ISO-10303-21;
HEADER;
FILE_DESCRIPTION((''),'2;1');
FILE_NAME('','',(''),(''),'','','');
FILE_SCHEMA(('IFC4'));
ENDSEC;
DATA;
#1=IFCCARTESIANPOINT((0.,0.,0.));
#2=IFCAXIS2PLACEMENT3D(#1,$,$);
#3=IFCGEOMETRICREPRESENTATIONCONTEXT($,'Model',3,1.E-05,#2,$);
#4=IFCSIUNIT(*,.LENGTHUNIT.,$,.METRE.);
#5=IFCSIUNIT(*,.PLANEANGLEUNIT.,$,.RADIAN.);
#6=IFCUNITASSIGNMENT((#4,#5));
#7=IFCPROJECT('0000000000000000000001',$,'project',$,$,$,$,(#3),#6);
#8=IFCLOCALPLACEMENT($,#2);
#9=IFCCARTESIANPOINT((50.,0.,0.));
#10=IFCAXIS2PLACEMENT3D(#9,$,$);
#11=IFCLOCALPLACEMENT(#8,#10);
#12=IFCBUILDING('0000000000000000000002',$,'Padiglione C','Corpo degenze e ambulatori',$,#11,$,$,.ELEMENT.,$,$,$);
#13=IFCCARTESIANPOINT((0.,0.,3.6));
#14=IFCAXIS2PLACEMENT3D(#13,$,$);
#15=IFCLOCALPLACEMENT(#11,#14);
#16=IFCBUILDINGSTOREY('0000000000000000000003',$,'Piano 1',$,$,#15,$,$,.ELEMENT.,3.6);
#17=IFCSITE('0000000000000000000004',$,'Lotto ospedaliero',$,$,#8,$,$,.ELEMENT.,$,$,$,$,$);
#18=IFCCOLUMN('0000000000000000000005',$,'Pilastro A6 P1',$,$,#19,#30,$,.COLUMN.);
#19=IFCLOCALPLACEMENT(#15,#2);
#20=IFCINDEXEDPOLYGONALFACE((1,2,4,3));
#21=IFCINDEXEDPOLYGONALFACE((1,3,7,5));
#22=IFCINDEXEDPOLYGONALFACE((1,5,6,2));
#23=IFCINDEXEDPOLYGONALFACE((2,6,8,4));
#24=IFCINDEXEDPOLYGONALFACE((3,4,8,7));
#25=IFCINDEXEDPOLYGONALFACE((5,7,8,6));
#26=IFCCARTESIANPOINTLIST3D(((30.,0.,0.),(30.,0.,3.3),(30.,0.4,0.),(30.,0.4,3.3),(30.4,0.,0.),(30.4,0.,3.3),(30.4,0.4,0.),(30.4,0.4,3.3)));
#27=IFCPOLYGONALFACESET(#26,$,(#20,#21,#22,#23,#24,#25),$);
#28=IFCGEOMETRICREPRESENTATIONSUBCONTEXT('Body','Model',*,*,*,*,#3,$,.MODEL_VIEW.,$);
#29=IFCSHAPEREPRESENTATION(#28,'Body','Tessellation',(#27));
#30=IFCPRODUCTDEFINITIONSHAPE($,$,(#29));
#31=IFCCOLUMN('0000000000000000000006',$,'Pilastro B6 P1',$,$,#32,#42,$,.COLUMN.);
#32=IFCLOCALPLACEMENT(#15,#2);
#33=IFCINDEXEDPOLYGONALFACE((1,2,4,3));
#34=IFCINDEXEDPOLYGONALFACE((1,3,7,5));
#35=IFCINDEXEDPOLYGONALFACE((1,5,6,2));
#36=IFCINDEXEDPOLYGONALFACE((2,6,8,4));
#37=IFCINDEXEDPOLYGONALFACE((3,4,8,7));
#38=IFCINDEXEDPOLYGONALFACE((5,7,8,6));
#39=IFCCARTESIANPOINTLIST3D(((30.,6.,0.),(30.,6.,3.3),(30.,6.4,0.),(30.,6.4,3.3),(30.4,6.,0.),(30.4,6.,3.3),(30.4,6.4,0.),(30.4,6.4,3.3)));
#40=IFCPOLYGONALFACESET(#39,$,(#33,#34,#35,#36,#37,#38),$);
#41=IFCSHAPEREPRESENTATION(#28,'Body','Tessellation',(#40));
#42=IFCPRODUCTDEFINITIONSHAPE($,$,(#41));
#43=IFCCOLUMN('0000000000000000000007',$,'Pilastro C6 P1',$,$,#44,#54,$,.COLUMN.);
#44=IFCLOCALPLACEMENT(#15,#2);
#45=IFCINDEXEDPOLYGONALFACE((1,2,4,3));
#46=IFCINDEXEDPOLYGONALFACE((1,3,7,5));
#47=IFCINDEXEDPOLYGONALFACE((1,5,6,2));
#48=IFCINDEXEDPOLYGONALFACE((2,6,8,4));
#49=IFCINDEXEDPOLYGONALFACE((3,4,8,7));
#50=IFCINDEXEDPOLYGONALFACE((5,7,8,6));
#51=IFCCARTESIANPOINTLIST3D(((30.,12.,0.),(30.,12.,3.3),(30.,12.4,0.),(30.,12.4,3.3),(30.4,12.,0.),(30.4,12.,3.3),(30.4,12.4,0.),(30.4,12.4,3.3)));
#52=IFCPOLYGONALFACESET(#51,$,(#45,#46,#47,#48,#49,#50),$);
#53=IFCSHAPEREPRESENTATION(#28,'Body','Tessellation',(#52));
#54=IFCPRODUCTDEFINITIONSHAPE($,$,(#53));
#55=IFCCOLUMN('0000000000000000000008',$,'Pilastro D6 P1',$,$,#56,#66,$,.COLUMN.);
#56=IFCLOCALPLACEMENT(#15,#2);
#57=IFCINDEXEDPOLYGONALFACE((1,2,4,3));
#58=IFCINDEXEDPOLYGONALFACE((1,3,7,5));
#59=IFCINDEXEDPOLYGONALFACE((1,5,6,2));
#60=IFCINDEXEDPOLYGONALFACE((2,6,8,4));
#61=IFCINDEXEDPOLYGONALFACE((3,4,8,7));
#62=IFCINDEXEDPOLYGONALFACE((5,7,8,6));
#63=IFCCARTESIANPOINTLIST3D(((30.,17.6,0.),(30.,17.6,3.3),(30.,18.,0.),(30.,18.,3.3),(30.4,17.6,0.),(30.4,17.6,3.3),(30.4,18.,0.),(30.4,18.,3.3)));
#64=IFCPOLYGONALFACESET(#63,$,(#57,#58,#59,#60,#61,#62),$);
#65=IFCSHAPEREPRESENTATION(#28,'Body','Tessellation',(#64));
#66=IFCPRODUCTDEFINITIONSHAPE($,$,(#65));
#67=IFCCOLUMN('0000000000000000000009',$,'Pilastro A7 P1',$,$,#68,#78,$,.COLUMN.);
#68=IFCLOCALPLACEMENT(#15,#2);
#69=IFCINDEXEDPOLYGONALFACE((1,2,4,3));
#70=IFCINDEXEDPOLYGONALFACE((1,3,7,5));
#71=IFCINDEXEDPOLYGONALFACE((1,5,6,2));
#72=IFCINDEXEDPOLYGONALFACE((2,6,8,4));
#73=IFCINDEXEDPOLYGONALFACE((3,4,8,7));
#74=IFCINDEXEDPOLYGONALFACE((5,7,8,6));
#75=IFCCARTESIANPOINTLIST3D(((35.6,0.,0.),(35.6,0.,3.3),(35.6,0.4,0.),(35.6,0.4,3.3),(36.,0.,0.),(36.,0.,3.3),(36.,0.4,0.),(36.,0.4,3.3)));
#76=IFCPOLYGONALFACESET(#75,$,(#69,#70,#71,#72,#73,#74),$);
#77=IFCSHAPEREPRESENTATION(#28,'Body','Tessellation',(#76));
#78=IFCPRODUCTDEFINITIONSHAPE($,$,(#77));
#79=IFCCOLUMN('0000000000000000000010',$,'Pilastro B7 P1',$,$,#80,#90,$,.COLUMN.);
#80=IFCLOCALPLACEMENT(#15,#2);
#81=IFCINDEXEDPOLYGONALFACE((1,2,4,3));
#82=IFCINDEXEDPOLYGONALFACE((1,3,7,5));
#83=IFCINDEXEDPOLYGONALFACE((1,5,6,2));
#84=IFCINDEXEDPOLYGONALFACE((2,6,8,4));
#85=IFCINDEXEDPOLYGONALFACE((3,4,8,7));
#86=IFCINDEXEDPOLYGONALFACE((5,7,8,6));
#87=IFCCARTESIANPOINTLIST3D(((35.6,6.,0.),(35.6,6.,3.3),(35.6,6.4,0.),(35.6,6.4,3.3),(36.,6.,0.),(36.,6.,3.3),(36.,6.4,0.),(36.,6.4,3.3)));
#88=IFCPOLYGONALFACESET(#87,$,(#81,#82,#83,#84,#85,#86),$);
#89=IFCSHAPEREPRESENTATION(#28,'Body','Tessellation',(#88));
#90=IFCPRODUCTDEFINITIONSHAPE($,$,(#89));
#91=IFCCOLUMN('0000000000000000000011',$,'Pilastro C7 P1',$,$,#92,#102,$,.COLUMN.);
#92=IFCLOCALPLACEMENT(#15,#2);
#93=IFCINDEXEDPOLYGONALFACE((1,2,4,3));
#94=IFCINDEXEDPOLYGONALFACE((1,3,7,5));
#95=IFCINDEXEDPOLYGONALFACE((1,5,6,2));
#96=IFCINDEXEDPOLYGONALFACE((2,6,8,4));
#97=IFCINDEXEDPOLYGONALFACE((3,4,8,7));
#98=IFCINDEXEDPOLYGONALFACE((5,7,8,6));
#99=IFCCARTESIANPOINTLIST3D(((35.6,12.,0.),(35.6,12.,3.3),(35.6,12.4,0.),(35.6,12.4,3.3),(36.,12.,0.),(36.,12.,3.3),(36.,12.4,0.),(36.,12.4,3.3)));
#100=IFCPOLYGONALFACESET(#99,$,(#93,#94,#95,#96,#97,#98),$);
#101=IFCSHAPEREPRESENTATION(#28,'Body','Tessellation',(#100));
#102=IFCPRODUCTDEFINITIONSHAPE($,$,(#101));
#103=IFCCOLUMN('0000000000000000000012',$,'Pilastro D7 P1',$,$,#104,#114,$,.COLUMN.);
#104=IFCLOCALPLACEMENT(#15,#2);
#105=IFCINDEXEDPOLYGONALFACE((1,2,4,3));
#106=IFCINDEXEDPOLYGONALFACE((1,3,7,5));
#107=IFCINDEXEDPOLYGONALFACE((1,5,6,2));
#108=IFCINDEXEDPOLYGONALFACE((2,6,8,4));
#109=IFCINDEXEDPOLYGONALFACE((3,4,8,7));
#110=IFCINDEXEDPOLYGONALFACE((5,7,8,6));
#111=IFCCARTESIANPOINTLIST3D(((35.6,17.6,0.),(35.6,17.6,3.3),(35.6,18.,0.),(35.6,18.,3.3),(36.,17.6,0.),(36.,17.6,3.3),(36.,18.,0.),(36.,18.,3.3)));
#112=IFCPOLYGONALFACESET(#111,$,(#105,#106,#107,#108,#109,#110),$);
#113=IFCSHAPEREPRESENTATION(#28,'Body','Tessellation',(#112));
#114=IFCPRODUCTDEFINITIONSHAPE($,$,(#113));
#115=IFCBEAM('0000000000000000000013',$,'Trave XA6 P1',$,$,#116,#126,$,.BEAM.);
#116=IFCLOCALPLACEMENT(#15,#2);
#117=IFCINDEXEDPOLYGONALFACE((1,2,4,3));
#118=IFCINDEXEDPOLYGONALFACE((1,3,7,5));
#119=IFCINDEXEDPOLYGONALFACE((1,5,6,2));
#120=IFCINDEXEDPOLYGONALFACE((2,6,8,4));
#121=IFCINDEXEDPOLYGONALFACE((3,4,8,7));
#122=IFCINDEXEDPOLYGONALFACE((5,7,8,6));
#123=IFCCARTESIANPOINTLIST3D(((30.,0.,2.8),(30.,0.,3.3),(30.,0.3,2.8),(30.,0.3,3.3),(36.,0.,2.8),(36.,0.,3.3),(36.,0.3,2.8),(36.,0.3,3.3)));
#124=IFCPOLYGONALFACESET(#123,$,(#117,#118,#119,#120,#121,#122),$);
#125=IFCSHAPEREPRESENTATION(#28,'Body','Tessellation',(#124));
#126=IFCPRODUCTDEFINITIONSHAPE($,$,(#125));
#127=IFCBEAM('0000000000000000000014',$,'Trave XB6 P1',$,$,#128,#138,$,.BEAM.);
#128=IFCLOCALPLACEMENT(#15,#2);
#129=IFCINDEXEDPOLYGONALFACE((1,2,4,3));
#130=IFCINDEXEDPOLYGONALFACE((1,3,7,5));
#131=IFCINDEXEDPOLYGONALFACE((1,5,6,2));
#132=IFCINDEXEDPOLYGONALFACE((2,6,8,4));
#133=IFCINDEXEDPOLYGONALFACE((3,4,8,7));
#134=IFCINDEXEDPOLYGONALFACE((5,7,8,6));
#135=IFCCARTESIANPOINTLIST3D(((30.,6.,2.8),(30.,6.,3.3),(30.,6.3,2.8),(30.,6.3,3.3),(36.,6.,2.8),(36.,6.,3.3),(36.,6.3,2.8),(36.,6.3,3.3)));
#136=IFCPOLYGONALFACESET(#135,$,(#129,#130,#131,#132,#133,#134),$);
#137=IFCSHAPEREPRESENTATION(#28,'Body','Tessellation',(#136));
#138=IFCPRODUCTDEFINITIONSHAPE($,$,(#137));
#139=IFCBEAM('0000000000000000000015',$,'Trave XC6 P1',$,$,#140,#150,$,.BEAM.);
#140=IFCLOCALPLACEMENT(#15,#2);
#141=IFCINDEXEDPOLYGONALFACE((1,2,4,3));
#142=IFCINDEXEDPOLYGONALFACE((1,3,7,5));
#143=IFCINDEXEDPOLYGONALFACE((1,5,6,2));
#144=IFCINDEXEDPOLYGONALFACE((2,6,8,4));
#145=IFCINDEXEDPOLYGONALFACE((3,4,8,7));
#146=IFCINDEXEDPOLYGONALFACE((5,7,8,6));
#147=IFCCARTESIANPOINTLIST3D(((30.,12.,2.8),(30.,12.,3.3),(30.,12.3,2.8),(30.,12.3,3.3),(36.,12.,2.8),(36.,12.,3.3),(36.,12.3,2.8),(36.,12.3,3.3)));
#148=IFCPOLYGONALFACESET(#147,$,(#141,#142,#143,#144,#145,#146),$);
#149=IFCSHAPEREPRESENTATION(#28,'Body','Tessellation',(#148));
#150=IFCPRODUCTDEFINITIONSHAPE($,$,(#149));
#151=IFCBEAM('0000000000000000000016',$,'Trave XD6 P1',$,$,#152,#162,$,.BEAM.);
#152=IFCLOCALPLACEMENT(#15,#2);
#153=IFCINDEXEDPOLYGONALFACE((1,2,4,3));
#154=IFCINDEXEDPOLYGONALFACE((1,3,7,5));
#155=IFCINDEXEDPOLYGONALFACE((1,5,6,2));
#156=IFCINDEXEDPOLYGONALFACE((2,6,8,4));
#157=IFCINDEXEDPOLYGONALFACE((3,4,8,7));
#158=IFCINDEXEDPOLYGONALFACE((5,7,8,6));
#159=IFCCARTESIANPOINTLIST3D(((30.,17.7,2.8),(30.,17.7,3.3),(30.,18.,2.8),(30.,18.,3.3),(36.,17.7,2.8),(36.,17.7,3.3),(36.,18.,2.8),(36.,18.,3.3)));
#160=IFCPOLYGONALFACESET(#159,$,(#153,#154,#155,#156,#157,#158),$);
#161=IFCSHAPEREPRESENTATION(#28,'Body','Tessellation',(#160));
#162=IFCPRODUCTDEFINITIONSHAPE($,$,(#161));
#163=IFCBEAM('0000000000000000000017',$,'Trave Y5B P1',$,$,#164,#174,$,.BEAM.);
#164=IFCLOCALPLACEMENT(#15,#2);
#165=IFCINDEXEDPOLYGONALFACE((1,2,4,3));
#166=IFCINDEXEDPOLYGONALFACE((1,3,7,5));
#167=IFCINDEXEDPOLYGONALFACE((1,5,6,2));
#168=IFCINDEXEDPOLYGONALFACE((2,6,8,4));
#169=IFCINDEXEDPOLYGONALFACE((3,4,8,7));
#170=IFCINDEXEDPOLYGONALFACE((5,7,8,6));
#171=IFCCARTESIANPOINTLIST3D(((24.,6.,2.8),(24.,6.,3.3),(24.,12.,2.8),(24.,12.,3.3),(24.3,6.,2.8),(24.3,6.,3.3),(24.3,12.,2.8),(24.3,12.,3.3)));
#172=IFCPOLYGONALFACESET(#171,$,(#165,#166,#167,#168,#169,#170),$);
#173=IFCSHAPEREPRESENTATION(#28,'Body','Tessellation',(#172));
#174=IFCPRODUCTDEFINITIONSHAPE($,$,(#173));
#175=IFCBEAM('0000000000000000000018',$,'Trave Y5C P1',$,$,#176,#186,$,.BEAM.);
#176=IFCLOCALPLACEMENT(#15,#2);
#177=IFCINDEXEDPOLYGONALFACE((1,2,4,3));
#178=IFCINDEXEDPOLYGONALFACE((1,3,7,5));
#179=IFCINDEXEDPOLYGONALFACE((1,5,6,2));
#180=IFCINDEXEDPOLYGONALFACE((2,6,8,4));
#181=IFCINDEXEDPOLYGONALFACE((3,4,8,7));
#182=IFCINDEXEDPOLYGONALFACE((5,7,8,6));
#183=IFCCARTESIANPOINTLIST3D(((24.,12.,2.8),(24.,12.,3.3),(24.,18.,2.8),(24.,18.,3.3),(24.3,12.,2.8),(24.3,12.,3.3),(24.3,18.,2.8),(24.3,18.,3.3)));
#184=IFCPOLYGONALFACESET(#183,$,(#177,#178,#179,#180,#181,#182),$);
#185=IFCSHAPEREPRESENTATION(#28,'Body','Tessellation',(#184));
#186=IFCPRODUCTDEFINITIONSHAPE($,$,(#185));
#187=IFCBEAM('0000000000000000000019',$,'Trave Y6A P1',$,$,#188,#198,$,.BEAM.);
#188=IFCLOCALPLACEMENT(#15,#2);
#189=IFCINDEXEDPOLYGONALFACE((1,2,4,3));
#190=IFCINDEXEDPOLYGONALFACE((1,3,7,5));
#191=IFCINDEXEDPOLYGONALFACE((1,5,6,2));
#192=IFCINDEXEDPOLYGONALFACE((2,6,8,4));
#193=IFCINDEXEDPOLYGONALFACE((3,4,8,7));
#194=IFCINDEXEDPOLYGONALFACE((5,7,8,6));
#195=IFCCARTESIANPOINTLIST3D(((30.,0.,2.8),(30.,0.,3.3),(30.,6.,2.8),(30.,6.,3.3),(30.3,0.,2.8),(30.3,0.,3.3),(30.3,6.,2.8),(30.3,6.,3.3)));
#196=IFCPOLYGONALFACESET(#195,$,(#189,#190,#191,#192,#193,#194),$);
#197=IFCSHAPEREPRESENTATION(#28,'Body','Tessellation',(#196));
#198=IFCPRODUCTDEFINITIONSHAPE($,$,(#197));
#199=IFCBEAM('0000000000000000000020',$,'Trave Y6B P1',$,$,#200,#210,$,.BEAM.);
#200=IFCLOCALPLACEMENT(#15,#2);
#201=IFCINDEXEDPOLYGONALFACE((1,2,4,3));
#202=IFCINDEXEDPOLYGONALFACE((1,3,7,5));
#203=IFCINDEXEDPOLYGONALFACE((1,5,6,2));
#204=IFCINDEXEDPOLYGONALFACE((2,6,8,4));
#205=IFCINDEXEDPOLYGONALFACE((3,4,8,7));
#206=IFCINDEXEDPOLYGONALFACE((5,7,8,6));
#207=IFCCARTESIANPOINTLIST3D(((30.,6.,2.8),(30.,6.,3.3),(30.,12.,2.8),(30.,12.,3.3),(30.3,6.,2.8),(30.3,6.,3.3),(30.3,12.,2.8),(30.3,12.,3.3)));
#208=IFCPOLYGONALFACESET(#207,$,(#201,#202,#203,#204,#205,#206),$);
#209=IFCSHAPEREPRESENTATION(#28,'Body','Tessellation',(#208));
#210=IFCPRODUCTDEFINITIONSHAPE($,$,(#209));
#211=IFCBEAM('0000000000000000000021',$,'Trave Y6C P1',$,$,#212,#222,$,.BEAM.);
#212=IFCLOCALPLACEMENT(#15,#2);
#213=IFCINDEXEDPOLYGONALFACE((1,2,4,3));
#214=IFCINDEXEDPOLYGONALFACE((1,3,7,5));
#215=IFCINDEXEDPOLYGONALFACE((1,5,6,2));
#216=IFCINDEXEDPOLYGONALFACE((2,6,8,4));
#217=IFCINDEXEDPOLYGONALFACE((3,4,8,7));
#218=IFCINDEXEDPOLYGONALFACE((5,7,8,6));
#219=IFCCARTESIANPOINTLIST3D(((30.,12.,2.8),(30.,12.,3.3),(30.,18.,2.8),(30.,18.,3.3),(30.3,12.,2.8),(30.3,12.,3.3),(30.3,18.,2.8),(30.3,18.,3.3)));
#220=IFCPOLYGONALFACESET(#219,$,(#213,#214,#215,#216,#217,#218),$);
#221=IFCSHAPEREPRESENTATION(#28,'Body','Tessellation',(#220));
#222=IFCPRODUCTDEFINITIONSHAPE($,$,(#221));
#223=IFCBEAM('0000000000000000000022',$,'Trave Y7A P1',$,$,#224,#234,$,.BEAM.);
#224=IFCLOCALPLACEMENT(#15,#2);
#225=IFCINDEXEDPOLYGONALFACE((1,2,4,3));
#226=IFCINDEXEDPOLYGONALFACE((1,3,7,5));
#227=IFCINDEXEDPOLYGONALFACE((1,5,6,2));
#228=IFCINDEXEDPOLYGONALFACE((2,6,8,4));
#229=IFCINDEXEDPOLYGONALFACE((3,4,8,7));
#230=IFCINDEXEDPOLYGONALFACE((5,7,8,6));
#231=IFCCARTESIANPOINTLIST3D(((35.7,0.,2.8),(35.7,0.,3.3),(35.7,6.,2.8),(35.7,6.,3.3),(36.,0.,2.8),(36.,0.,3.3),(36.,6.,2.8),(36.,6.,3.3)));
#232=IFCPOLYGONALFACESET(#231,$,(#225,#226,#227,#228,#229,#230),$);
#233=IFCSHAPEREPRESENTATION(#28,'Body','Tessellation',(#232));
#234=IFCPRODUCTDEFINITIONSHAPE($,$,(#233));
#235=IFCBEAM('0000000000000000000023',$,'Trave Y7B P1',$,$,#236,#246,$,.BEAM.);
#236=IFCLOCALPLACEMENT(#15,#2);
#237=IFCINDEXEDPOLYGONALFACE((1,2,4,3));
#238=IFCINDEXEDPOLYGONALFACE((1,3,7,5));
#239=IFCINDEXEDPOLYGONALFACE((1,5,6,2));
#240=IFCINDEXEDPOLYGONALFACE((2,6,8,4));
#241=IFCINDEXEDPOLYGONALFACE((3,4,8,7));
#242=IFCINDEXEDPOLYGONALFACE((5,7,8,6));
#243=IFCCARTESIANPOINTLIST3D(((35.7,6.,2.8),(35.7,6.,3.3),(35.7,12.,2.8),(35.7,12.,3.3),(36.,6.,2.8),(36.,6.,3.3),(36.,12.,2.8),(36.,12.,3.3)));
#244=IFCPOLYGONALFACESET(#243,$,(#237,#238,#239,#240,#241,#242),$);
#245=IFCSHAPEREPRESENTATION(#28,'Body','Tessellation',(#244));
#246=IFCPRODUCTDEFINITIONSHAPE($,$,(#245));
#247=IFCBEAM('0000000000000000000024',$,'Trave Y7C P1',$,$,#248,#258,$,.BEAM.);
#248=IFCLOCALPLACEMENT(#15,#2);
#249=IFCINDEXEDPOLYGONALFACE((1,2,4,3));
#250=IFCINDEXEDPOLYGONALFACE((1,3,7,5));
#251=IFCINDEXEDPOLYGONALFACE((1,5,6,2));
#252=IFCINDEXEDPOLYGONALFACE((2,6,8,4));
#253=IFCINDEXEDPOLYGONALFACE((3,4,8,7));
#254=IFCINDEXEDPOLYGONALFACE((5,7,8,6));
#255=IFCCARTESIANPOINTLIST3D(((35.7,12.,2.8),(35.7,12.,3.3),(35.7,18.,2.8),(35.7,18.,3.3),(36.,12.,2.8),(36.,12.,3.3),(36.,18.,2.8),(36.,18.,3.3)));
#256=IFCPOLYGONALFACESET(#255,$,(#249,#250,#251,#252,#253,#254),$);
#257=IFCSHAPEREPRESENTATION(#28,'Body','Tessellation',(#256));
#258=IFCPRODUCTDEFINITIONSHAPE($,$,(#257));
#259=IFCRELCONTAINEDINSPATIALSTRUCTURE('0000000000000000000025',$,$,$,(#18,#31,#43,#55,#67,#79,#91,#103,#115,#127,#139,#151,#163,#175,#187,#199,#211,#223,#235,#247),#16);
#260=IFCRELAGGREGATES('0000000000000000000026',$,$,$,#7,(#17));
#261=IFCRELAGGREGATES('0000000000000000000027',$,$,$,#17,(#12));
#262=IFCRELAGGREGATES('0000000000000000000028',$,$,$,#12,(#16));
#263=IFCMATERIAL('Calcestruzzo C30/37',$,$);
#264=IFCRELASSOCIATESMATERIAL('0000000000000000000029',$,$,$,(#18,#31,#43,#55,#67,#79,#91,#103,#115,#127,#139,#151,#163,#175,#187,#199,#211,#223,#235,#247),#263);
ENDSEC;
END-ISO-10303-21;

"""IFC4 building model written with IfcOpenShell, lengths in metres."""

from ifc_helpers import new_model, si_unit, frame, frame_2d, origin, place, context, subcontext, project, spatial, rectangle, extrude, material, element, save


model = new_model("IFC4")

# Units and contexts
model_context = context("Model", 3, precision=1e-05, world=origin())
body_context = subcontext(model_context, "Body", "Model", "MODEL_VIEW")
ifc_project = project(units=[si_unit("LENGTHUNIT", "METRE"), si_unit("PLANEANGLEUNIT", "RADIAN")], contexts=[model_context])

# Site, building, storey
site_placement = place(None, origin())
site = spatial("IfcSite", under=ifc_project, at=site_placement, Name="Lotto ospedaliero", CompositionType="ELEMENT")
building_placement = place(site_placement, frame((50.0, 0.0, 0.0)))
building = spatial("IfcBuilding", under=site, at=building_placement, Name="Padiglione C", Description="Corpo degenze e ambulatori", CompositionType="ELEMENT")
storey_placement = place(building_placement, frame((0.0, 0.0, 3.6)))
storey = spatial("IfcBuildingStorey", under=building, at=storey_placement, Name="Piano 1", CompositionType="ELEMENT", Elevation=3.6)

# Columns
ifc_material_1 = material(Name="Calcestruzzo C30/37")
for number, where, name in (
    (1, (30.0, 0.0, 0.0), "Pilastro A6 P1"),
    (2, (30.0, 6.0, 0.0), "Pilastro B6 P1"),
    (3, (30.0, 12.0, 0.0), "Pilastro C6 P1"),
    (4, (30.0, 17.6, 0.0), "Pilastro D6 P1"),
    (5, (35.6, 0.0, 0.0), "Pilastro A7 P1"),
    (6, (35.6, 6.0, 0.0), "Pilastro B7 P1"),
    (7, (35.6, 12.0, 0.0), "Pilastro C7 P1"),
    (8, (35.6, 17.6, 0.0), "Pilastro D7 P1"),
):
    element("IfcColumn", number, at=place(storey_placement, frame(where)), inside=storey, material=ifc_material_1, Name=name, PredefinedType="COLUMN", context=body_context, shape_type="SweptSolid", body=[
        extrude(rectangle(XDim=0.4, YDim=0.4, at=frame_2d((0.2, 0.2))), origin(), (0.0, 0.0, 1.0), 3.3),
    ])

# Beams
for number, where, name in (
    (9, (30.0, 0.0, 2.8), "Trave XA6 P1"),
    (10, (30.0, 6.0, 2.8), "Trave XB6 P1"),
    (11, (30.0, 12.0, 2.8), "Trave XC6 P1"),
    (12, (30.0, 17.7, 2.8), "Trave XD6 P1"),
):
    element("IfcBeam", number, at=place(storey_placement, frame(where)), inside=storey, material=ifc_material_1, Name=name, PredefinedType="BEAM", context=body_context, shape_type="SweptSolid", body=[
        extrude(rectangle(XDim=6.0, YDim=0.3, at=frame_2d((3.0, 0.15))), origin(), (0.0, 0.0, 1.0), 0.5),
    ])
for number, where, name in (
    (13, (24.0, 6.0, 2.8), "Trave Y5B P1"),
    (14, (24.0, 12.0, 2.8), "Trave Y5C P1"),
    (15, (30.0, 0.0, 2.8), "Trave Y6A P1"),
    (16, (30.0, 6.0, 2.8), "Trave Y6B P1"),
    (17, (30.0, 12.0, 2.8), "Trave Y6C P1"),
    (18, (35.7, 0.0, 2.8), "Trave Y7A P1"),
    (19, (35.7, 6.0, 2.8), "Trave Y7B P1"),
    (20, (35.7, 12.0, 2.8), "Trave Y7C P1"),
):
    element("IfcBeam", number, at=place(storey_placement, frame(where)), inside=storey, material=ifc_material_1, Name=name, PredefinedType="BEAM", context=body_context, shape_type="SweptSolid", body=[
        extrude(rectangle(XDim=0.3, YDim=6.0, at=frame_2d((0.15, 3.0))), origin(), (0.0, 0.0, 1.0), 0.5),
    ])

save(model, "model.ifc")
